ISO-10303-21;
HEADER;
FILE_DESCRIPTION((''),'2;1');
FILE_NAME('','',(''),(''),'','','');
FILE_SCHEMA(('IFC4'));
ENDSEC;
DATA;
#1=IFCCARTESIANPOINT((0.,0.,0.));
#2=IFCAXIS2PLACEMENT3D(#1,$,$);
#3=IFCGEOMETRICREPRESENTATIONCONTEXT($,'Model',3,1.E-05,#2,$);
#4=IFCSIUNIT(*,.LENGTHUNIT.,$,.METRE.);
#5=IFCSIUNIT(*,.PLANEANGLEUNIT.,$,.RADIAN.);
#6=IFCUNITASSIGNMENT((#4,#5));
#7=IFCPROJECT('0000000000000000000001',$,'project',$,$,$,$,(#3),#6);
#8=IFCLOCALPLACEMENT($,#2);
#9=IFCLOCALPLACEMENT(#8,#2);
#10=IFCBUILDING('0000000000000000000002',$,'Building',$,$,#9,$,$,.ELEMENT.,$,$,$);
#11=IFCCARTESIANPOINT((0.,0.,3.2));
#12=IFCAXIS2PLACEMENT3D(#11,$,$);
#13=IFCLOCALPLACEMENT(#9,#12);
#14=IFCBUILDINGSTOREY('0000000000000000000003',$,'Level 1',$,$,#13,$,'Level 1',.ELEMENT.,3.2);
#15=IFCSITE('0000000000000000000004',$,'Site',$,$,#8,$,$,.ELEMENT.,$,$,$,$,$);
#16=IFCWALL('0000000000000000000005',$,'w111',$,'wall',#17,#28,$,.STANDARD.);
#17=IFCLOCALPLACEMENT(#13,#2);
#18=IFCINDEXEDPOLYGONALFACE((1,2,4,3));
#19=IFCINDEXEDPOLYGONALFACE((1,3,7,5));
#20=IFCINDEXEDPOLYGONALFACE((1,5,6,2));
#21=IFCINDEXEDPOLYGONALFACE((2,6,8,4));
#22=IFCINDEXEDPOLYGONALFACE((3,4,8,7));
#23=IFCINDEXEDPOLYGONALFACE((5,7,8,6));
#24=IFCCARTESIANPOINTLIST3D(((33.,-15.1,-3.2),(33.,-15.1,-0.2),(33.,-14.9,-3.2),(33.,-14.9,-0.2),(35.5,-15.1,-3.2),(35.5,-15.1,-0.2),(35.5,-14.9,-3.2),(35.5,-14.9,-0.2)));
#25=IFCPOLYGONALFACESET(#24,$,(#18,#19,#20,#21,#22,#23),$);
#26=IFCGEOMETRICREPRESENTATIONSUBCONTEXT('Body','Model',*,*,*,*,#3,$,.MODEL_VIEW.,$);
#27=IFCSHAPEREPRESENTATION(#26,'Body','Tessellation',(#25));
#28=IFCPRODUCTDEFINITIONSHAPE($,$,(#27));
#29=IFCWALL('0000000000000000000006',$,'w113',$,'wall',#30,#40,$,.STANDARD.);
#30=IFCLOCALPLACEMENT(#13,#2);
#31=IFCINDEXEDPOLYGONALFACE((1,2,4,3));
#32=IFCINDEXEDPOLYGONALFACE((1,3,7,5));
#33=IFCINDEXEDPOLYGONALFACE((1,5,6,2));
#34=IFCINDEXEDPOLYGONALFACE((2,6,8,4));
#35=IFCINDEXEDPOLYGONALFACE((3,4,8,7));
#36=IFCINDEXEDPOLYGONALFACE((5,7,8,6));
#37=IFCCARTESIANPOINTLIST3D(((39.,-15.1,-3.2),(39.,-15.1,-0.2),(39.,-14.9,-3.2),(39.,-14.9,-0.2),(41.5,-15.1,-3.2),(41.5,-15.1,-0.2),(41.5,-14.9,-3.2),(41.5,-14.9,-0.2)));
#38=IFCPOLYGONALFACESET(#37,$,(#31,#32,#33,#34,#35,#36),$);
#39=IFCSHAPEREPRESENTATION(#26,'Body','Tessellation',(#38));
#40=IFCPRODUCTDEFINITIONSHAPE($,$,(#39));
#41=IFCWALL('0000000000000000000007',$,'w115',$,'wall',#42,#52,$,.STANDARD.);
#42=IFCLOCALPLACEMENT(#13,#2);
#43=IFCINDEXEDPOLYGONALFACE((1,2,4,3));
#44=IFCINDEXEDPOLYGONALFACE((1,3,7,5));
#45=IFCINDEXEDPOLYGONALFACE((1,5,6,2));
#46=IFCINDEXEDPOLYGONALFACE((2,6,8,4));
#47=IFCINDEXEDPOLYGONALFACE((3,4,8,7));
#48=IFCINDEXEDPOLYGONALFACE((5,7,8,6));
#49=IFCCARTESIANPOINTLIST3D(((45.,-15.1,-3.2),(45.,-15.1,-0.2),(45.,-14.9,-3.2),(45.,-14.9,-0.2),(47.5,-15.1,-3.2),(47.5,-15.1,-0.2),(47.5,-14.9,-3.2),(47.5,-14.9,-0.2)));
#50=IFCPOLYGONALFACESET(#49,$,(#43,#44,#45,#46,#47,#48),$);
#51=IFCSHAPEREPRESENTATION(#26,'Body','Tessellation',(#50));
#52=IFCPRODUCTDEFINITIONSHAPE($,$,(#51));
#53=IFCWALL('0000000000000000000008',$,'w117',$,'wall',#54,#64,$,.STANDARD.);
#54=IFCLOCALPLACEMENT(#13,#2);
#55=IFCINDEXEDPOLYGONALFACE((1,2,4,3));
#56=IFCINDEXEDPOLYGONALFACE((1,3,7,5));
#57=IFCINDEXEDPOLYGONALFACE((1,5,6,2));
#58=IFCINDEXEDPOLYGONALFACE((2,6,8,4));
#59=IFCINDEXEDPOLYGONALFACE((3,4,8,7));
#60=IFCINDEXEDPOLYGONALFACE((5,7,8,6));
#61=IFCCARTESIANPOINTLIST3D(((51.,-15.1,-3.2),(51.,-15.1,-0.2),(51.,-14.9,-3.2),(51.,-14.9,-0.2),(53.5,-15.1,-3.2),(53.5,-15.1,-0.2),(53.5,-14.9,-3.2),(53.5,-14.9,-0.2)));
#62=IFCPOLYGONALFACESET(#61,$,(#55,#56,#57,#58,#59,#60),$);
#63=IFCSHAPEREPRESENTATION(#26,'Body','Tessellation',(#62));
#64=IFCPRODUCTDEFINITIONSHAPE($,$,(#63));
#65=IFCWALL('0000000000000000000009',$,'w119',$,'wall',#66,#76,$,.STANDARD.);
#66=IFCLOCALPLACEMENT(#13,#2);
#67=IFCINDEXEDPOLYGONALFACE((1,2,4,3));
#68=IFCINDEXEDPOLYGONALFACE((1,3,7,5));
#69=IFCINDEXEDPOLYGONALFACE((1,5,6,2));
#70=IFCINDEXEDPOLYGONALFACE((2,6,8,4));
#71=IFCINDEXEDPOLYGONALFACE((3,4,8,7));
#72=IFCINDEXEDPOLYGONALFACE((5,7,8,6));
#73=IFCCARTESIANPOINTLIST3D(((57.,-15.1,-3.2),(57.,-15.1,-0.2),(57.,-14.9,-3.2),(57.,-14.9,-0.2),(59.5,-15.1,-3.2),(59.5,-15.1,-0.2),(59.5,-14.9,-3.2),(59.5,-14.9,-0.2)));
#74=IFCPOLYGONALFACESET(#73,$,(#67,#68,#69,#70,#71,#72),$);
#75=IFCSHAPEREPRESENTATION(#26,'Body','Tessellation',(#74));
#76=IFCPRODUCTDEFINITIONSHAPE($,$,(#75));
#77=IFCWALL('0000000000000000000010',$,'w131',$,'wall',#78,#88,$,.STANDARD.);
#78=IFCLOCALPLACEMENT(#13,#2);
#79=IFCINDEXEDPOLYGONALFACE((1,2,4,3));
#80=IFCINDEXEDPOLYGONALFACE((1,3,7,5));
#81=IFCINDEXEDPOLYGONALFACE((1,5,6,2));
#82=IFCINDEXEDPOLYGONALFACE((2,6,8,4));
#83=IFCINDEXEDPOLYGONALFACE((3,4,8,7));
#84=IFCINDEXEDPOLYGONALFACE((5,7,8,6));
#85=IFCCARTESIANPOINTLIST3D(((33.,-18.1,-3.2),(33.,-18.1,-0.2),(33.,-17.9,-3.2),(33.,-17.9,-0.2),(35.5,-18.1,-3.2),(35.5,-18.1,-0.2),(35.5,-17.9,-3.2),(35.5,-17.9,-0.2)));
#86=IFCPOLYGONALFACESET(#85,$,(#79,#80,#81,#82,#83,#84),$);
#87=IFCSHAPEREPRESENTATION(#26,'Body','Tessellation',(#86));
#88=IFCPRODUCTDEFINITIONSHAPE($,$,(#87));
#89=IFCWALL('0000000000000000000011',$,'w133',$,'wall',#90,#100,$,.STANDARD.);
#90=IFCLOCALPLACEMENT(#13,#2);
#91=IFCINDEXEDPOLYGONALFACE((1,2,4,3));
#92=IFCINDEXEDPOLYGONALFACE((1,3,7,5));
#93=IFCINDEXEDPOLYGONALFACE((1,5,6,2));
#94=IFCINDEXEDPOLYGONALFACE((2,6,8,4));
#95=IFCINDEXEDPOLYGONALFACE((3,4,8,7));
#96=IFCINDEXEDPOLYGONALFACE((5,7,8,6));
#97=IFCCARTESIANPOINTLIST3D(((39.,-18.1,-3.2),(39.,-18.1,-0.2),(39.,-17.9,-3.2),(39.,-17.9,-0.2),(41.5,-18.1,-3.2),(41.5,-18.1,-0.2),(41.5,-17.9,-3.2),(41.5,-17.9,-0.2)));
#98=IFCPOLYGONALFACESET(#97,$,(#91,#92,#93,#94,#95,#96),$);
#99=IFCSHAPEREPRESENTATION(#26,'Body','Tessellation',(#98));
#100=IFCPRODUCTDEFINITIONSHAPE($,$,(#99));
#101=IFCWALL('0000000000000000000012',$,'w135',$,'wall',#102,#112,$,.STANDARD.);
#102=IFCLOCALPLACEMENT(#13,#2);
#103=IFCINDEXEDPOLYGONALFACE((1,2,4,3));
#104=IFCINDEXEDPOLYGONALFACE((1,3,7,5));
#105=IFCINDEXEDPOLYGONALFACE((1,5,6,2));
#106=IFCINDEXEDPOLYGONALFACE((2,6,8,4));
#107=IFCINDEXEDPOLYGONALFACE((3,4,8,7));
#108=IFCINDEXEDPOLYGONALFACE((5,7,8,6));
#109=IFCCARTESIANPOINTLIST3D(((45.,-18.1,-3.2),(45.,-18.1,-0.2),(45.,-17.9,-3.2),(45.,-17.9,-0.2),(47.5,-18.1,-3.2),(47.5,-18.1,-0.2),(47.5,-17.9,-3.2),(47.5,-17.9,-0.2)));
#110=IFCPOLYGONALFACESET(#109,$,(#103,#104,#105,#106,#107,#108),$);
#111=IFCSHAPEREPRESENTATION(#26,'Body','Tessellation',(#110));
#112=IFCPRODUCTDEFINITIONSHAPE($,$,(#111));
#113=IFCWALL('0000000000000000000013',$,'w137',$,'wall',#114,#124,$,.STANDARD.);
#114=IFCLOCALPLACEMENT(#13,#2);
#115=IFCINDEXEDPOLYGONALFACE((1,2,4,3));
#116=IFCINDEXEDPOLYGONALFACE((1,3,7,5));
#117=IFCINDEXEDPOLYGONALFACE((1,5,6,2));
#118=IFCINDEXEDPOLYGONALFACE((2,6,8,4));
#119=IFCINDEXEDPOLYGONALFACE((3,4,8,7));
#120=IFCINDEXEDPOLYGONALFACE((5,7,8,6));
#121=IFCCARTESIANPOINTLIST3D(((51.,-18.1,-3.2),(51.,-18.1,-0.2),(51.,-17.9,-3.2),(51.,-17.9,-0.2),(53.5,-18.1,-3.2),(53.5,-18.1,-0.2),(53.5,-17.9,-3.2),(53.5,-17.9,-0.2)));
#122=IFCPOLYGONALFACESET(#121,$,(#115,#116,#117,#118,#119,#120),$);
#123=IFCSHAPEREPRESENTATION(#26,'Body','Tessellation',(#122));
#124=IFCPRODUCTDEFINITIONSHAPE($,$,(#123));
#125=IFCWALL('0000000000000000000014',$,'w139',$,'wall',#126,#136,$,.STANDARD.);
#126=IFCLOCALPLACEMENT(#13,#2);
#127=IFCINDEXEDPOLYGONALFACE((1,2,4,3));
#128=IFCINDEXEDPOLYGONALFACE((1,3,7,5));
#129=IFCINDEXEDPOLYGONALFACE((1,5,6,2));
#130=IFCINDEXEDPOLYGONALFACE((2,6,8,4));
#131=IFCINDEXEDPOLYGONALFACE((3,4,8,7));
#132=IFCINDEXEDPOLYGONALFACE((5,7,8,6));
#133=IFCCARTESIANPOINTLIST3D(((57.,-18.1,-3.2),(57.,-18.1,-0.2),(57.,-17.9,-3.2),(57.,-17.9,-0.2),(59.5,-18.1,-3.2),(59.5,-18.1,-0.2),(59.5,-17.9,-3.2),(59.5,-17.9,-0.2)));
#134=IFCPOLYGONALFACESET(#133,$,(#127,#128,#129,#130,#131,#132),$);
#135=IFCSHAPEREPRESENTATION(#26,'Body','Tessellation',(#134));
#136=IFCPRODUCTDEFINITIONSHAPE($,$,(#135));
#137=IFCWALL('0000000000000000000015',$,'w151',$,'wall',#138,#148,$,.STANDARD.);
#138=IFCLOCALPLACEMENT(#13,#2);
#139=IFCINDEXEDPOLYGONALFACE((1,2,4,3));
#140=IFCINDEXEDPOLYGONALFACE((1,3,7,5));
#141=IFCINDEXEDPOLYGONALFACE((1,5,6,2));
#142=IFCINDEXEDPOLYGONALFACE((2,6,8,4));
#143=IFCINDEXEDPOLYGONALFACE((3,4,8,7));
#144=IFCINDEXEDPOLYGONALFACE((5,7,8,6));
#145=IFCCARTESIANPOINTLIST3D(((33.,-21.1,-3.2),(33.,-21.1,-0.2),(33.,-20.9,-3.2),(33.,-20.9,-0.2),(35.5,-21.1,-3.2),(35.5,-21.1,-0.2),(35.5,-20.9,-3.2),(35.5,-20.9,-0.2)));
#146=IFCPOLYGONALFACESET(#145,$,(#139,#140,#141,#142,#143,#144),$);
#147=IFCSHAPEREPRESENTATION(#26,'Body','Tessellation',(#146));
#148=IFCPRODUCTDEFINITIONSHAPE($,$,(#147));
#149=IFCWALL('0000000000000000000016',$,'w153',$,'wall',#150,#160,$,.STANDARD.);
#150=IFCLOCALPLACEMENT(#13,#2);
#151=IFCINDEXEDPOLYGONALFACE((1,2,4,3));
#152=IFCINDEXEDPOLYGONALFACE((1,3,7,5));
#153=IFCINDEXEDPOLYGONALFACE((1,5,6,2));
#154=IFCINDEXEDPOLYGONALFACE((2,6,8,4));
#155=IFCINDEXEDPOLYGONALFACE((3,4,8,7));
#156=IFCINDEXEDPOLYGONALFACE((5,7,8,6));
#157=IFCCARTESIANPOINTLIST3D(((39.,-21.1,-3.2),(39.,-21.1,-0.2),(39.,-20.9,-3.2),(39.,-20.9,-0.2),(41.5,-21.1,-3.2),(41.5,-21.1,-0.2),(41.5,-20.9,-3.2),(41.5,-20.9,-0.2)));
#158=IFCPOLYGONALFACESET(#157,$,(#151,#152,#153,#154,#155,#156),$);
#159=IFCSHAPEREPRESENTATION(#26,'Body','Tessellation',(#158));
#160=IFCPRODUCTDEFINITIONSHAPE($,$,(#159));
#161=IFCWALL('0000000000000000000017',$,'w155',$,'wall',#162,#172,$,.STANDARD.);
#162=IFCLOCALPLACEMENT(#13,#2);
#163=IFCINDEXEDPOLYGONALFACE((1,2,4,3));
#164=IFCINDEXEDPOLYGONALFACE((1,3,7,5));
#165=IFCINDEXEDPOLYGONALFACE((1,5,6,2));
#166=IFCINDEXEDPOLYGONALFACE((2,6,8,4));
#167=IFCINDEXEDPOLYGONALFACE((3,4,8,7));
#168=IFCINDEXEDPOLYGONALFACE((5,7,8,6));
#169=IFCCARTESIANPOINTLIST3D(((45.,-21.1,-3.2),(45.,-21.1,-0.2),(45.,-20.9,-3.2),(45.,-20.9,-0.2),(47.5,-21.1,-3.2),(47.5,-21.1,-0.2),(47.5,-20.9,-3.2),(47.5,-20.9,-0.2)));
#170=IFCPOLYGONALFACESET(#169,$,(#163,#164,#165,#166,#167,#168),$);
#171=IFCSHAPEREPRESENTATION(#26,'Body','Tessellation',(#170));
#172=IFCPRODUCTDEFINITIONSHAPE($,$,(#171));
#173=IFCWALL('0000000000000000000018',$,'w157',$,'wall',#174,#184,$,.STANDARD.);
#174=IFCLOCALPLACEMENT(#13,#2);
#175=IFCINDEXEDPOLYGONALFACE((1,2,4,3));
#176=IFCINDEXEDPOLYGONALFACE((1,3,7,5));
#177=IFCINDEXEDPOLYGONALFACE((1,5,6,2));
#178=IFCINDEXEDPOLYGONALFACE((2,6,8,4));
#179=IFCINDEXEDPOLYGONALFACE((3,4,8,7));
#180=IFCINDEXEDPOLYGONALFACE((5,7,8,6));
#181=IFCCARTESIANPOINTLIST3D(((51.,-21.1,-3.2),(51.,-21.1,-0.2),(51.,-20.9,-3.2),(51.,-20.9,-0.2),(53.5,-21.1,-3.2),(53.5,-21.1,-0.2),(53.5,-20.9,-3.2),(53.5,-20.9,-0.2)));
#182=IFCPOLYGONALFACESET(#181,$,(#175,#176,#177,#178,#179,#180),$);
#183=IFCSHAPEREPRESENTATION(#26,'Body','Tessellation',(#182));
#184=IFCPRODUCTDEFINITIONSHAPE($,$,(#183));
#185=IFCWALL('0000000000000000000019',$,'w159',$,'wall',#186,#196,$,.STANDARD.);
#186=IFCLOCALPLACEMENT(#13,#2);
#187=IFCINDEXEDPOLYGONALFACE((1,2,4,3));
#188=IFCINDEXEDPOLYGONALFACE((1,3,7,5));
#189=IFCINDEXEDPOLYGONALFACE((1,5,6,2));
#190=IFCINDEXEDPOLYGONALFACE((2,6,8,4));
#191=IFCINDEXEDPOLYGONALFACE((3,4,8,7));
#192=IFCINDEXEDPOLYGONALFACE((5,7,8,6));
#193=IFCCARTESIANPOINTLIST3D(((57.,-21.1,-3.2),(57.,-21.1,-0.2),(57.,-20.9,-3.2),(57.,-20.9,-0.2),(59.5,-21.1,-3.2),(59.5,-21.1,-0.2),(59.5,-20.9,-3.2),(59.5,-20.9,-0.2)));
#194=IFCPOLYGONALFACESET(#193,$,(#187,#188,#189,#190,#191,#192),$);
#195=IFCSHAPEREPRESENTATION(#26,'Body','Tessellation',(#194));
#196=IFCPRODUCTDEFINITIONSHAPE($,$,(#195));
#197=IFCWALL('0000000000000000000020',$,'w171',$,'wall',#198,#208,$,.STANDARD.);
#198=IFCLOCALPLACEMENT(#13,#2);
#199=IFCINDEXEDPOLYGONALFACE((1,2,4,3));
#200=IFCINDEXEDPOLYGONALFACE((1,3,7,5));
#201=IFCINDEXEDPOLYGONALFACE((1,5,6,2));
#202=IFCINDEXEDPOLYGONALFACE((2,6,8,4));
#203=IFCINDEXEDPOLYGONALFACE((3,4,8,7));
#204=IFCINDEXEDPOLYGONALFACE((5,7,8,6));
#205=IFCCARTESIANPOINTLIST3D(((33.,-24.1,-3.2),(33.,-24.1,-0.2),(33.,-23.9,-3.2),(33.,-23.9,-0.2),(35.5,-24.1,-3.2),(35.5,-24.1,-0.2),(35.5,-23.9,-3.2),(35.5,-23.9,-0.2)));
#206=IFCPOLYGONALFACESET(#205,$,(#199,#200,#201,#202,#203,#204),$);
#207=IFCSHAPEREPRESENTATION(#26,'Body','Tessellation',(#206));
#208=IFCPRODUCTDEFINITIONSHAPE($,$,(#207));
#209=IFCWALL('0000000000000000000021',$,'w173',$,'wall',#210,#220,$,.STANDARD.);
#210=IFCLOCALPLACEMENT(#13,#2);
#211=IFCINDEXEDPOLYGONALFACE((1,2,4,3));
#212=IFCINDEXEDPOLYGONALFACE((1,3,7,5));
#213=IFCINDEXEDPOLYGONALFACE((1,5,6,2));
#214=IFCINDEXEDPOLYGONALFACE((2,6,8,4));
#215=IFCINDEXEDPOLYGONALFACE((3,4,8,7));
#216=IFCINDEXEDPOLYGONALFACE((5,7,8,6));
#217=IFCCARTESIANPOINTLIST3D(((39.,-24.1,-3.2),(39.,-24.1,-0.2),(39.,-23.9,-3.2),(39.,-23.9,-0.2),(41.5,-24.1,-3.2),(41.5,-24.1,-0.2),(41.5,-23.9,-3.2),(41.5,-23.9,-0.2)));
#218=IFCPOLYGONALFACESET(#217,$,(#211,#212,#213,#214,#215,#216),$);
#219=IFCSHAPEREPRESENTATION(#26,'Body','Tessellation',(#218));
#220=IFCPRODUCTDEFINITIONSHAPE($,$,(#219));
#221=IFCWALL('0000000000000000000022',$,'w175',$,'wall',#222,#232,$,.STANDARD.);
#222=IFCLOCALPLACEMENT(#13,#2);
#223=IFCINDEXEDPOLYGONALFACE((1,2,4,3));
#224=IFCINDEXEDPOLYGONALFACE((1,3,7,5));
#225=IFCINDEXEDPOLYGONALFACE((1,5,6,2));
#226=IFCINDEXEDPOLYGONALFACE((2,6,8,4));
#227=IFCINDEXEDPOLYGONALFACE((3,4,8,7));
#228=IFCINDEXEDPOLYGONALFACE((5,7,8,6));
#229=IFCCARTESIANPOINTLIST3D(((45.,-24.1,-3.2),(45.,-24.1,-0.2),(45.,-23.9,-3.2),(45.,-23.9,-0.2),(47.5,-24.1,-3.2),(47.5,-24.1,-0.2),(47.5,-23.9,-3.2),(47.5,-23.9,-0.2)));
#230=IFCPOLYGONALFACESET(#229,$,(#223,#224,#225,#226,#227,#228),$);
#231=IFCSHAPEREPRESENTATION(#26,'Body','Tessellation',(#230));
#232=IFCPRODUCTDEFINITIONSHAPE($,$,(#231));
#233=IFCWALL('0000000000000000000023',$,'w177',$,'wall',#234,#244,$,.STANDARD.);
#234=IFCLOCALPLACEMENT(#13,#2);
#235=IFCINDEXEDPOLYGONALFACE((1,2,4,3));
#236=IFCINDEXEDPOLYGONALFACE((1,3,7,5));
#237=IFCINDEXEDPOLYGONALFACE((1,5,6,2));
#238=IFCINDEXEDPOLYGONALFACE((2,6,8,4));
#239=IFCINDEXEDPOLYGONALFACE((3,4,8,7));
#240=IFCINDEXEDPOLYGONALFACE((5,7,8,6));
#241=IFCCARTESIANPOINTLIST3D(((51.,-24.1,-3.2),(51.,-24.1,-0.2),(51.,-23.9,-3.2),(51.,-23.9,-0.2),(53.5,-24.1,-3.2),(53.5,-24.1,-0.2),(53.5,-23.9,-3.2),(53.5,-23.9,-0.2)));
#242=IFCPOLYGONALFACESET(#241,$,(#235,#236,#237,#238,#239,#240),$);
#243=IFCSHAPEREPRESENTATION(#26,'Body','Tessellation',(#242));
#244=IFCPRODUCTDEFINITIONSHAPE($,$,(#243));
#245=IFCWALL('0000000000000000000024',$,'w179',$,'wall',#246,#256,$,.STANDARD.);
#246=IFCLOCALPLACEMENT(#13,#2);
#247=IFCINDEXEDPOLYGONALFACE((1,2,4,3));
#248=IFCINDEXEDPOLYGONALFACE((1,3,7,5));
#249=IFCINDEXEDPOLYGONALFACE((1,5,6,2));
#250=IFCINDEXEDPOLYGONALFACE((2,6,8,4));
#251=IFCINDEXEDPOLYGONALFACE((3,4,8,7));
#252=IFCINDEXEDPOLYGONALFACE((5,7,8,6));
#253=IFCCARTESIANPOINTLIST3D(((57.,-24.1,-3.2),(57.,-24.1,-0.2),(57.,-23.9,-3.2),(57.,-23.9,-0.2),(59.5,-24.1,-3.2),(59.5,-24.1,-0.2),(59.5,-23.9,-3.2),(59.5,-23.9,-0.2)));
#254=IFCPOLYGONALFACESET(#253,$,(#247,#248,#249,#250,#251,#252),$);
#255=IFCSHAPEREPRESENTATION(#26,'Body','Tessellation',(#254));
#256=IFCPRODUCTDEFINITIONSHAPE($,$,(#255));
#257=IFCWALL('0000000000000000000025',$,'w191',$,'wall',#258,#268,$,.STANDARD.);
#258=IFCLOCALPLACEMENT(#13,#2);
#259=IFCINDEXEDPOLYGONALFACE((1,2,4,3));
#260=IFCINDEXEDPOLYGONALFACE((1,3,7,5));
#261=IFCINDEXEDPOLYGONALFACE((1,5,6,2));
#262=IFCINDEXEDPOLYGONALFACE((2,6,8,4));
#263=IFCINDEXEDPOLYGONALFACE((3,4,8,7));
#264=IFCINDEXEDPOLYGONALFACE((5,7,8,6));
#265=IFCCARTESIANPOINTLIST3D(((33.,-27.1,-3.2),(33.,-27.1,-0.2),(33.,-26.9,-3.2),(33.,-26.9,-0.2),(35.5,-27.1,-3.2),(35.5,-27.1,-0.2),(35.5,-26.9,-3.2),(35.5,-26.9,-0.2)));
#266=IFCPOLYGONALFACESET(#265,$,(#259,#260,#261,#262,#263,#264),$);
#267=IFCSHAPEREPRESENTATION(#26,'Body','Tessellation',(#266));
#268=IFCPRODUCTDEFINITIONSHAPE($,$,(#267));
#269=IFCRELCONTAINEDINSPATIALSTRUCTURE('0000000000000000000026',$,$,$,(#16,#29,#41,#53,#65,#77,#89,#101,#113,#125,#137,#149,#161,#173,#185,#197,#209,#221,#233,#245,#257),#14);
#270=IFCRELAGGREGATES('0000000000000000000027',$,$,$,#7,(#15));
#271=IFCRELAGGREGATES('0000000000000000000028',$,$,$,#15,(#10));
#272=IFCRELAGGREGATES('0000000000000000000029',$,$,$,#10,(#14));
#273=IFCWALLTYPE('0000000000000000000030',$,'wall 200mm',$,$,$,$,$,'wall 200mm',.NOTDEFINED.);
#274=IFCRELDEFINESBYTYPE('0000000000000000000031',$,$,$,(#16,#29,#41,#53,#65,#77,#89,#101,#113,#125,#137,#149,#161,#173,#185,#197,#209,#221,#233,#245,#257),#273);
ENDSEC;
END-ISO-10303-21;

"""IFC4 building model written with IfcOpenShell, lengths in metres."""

from ifc_helpers import new_model, si_unit, frame, frame_2d, origin, place, context, subcontext, project, spatial, rectangle, extrude, type_object, element, save


model = new_model("IFC4")

# Units and contexts
model_context = context("Model", 3, precision=1e-05, world=origin())
body_context = subcontext(model_context, "Body", "Model", "MODEL_VIEW")
ifc_project = project(units=[si_unit("LENGTHUNIT", "METRE"), si_unit("PLANEANGLEUNIT", "RADIAN")], contexts=[model_context])

# Site, building, storey
site_placement = place(None, origin())
site = spatial("IfcSite", under=ifc_project, at=site_placement, Name="Site", CompositionType="ELEMENT")
building_placement = place(site_placement, origin())
building = spatial("IfcBuilding", under=site, at=building_placement, Name="Building", CompositionType="ELEMENT")
storey_placement = place(building_placement, frame((0.0, 0.0, 3.2)))
storey = spatial("IfcBuildingStorey", under=building, at=storey_placement, Name="Level 1", LongName="Level 1", CompositionType="ELEMENT", Elevation=3.2)

# Walls
wall_type = type_object("IfcWallType", Name="wall 200mm", ElementType="wall 200mm", PredefinedType="NOTDEFINED")
for number, where, z_axis, x_axis, name in (
    (1, (33.0, -15.0, -3.2), (0.0, 0.0, 1.0), (1.0, 0.0, 0.0), "w111"),
    (2, (39.0, -15.0, -3.2), (0.0, 0.0, 1.0), (1.0, 0.0, 0.0), "w113"),
    (3, (45.0, -15.0, -3.2), (0.0, 0.0, 1.0), (1.0, 0.0, 0.0), "w115"),
    (4, (51.0, -15.0, -3.2), (0.0, 0.0, 1.0), (1.0, 0.0, 0.0), "w117"),
    (5, (57.0, -15.0, -3.2), (0.0, 0.0, 1.0), (1.0, 0.0, 0.0), "w119"),
    (6, (33.0, -18.0, -3.2), (0.0, 0.0, 1.0), (1.0, 0.0, 0.0), "w131"),
    (7, (39.0, -18.0, -3.2), (0.0, 0.0, 1.0), (1.0, 0.0, 0.0), "w133"),
    (8, (45.0, -18.0, -3.2), (0.0, 0.0, 1.0), (1.0, 0.0, 0.0), "w135"),
    (9, (51.0, -18.0, -3.2), (0.0, 0.0, 1.0), (1.0, 0.0, 0.0), "w137"),
    (10, (57.0, -18.0, -3.2), (0.0, 0.0, 1.0), (1.0, 0.0, 0.0), "w139"),
    (11, (33.0, -21.0, -3.2), (0.0, 0.0, 1.0), (1.0, 0.0, 0.0), "w151"),
    (12, (39.0, -21.0, -3.2), (0.0, 0.0, 1.0), (1.0, 0.0, 0.0), "w153"),
    (13, (45.0, -21.0, -3.2), (0.0, 0.0, 1.0), (1.0, 0.0, 0.0), "w155"),
    (14, (51.0, -21.0, -3.2), (0.0, 0.0, 1.0), (1.0, 0.0, 0.0), "w157"),
    (15, (57.0, -21.0, -3.2), (0.0, 0.0, 1.0), (1.0, 0.0, 0.0), "w159"),
    (16, (33.0, -24.0, -3.2), (0.0, 0.0, 1.0), (1.0, 0.0, 0.0), "w171"),
    (17, (39.0, -24.0, -3.2), (0.0, 0.0, 1.0), (1.0, 0.0, 0.0), "w173"),
    (18, (45.0, -24.0, -3.2), (0.0, 0.0, 1.0), (1.0, 0.0, 0.0), "w175"),
    (19, (51.0, -24.0, -3.2), (0.0, 0.0, 1.0), (1.0, 0.0, 0.0), "w177"),
    (20, (57.0, -24.0, -3.2), (0.0, 0.0, 1.0), (1.0, 0.0, 0.0), "w179"),
    (21, (33.0, -27.0, -3.2), (0.0, 0.0, 1.0), (1.0, 0.0, 0.0), "w191"),
):
    element("IfcWall", number, at=place(storey_placement, frame(where, z_axis=z_axis, x_axis=x_axis)), inside=storey, type_object=wall_type, Name=name, ObjectType="wall", PredefinedType="STANDARD", context=body_context, shape_type="SweptSolid", body=[
        extrude(rectangle(XDim=2.5, YDim=0.2, at=frame_2d((1.25, 0.0))), origin(), (0.0, 0.0, 1.0), 3.0),
    ])

save(model, "model.ifc")
